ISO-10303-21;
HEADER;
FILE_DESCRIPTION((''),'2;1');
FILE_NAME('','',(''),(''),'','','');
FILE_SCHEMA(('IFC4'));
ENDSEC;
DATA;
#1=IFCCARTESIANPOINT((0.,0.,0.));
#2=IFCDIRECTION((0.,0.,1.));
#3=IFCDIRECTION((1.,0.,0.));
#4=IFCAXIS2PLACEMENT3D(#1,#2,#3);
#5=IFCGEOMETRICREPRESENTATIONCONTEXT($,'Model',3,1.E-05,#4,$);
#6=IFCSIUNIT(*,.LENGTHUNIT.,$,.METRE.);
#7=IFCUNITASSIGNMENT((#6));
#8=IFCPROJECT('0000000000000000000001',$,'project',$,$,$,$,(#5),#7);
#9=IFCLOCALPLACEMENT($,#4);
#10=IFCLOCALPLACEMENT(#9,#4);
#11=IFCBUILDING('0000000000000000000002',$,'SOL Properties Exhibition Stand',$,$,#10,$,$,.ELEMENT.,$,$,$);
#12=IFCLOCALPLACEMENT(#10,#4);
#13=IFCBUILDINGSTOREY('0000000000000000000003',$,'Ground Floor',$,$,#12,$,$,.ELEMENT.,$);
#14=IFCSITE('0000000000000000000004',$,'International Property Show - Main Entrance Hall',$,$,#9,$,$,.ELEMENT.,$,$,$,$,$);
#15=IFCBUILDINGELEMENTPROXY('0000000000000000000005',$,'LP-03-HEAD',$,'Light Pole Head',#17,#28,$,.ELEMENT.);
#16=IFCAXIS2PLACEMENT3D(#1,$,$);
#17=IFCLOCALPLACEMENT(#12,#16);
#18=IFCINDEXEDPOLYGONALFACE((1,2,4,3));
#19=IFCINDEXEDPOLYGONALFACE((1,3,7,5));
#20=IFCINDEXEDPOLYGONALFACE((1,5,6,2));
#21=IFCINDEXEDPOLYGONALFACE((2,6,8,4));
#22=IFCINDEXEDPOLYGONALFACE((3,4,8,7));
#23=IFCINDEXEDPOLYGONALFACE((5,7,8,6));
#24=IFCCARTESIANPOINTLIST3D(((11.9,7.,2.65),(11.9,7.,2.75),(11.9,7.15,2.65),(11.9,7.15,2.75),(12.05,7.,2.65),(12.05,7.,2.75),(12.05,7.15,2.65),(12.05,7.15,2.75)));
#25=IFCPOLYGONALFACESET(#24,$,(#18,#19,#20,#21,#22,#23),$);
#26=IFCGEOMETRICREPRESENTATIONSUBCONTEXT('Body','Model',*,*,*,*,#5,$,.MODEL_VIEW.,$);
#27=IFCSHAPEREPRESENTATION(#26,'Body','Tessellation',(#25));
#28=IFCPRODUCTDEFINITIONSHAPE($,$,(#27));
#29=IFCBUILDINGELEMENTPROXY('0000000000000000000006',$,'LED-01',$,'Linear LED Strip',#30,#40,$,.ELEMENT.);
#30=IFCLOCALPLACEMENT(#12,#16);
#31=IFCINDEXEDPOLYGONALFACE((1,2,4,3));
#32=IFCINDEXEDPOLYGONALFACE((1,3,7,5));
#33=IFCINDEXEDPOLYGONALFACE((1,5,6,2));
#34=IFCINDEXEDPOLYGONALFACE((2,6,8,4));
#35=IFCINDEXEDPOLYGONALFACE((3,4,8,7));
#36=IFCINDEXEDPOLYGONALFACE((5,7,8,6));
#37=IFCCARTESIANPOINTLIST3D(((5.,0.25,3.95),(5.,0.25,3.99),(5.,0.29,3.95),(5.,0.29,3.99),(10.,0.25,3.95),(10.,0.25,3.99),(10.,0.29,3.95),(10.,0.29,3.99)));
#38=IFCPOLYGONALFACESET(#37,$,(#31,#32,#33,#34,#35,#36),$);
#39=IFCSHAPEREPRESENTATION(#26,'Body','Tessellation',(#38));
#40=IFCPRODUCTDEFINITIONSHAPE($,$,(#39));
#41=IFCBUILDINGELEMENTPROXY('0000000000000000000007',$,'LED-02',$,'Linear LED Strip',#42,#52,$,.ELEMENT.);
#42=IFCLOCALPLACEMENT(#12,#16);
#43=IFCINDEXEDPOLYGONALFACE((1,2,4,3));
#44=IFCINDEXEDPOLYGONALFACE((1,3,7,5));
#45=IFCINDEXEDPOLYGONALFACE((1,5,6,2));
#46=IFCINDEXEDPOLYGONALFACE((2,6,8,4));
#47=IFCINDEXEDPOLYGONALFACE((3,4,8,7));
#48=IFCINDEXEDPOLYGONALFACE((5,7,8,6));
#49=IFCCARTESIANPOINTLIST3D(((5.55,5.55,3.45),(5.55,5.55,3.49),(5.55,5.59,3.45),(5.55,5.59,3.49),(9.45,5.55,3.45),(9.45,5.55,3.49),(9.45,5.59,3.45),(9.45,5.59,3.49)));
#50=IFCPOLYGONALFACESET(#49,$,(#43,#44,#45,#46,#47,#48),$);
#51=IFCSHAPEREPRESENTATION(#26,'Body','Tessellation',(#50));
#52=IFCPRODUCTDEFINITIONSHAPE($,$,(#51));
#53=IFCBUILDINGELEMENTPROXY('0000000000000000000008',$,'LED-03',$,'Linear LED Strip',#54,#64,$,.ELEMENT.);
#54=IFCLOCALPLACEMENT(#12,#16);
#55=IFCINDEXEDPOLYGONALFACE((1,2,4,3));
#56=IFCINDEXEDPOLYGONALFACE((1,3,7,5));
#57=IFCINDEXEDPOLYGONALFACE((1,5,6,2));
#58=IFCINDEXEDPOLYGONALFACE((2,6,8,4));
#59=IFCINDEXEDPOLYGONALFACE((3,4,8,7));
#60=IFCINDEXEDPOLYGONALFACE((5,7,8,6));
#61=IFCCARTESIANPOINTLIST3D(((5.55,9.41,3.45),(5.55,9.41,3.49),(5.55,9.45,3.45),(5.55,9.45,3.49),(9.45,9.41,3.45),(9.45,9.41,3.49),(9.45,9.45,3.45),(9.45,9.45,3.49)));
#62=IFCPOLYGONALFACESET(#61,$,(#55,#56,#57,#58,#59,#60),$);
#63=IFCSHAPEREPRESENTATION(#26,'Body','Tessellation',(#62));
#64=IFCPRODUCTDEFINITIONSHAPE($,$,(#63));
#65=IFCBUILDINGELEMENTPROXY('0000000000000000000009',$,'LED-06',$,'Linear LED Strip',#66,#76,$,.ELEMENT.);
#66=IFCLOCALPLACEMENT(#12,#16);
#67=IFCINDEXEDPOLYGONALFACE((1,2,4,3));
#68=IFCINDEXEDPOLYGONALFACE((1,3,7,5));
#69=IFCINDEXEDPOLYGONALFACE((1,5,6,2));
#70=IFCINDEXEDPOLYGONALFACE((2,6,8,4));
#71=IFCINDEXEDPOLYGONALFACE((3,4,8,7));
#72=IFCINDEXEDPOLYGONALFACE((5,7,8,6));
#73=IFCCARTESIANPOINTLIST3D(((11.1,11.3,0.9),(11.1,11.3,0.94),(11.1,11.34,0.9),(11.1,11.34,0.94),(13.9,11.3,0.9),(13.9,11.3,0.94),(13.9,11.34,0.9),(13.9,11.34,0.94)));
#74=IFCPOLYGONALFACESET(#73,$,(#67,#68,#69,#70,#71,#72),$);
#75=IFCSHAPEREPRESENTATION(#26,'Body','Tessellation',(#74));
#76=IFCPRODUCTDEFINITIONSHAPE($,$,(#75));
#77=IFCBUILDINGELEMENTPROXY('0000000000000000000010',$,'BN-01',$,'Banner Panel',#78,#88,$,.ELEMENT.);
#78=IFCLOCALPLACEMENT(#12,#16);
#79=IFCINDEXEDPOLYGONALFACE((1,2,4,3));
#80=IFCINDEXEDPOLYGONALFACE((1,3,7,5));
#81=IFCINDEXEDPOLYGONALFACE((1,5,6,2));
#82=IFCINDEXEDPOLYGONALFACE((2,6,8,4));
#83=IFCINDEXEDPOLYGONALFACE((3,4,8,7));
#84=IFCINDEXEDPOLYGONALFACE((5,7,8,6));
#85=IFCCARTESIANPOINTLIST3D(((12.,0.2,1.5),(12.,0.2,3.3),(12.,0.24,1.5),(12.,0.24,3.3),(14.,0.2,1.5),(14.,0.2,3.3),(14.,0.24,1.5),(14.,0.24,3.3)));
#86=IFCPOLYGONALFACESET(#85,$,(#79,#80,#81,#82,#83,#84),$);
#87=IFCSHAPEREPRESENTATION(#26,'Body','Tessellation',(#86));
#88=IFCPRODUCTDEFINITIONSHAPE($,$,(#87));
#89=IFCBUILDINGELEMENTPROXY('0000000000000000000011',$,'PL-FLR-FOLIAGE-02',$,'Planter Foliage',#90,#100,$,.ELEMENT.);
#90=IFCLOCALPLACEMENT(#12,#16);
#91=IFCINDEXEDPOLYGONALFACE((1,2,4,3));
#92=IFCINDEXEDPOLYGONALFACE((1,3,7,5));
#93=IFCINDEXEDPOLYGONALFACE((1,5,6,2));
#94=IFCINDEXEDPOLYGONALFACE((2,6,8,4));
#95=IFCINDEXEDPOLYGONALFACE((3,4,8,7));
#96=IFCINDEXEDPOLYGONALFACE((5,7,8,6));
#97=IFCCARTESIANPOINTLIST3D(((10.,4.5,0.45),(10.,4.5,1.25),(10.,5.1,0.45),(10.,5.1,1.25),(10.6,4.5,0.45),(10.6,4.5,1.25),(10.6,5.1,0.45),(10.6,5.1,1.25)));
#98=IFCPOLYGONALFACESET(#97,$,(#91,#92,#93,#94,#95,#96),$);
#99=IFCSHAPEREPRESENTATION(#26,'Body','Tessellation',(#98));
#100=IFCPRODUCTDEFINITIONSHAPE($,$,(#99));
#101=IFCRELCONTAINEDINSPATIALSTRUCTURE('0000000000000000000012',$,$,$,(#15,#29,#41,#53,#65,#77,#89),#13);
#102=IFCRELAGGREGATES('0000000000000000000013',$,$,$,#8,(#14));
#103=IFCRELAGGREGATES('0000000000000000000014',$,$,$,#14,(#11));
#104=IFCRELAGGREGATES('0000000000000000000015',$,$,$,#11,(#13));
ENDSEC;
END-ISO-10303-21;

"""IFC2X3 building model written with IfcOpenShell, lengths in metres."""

from ifc_helpers import new_model, si_unit, frame, frame_2d, origin, origin_with_axes, place, context, subcontext, project, spatial, rectangle, extrude, element, save


model = new_model("IFC2X3")

# Units and contexts
model_context = context("Model", 3, precision=1e-05, world=origin_with_axes())
body_context = subcontext(model_context, "Body", "Model", "MODEL_VIEW")
ifc_project = project(units=[si_unit("LENGTHUNIT", "METRE")], contexts=[model_context])

# Site, building, storey
site_placement = place(None, origin_with_axes())
site = spatial("IfcSite", under=ifc_project, at=site_placement, Name="International Property Show - Main Entrance Hall", CompositionType="ELEMENT")
building_placement = place(site_placement, origin_with_axes())
building = spatial("IfcBuilding", under=site, at=building_placement, Name="SOL Properties Exhibition Stand", CompositionType="ELEMENT")
storey_placement = place(building_placement, origin_with_axes())
storey = spatial("IfcBuildingStorey", under=building, at=storey_placement, Name="Ground Floor", CompositionType="ELEMENT")

# Building element proxies
for number, where, z_axis, x_axis, name in (
    (1, (11.9, 7.0, 2.65), (0.0, 0.0, 1.0), (1.0, 0.0, 0.0), "LP-03-HEAD"),
):
    element("IfcBuildingElementProxy", number, at=place(storey_placement, frame(where, z_axis=z_axis, x_axis=x_axis)), inside=storey, Name=name, ObjectType="Light Pole Head", CompositionType="ELEMENT", context=body_context, shape_type="SweptSolid", body=[
        extrude(rectangle(XDim=0.15, YDim=0.15, at=frame_2d((0.075, 0.075))), origin(), (0.0, 0.0, 1.0), 0.1),
    ])
proxy_1_placement = place(storey_placement, frame((5.0, 0.25, 3.95), z_axis=(0.0, 0.0, 1.0), x_axis=(1.0, 0.0, 0.0)))
element("IfcBuildingElementProxy", 2, at=proxy_1_placement, inside=storey, Name="LED-01", ObjectType="Linear LED Strip", CompositionType="ELEMENT", context=body_context, shape_type="SweptSolid", body=[
    extrude(rectangle(XDim=5.0, YDim=0.04, at=frame_2d((2.5, 0.02))), origin(), (0.0, 0.0, 1.0), 0.04),
])
for number, where, z_axis, x_axis, name in (
    (3, (5.55, 5.55, 3.45), (0.0, 0.0, 1.0), (1.0, 0.0, 0.0), "LED-02"),
    (4, (5.55, 9.41, 3.45), (0.0, 0.0, 1.0), (1.0, 0.0, 0.0), "LED-03"),
):
    element("IfcBuildingElementProxy", number, at=place(storey_placement, frame(where, z_axis=z_axis, x_axis=x_axis)), inside=storey, Name=name, ObjectType="Linear LED Strip", CompositionType="ELEMENT", context=body_context, shape_type="SweptSolid", body=[
        extrude(rectangle(XDim=3.9, YDim=0.04, at=frame_2d((1.95, 0.02))), origin(), (0.0, 0.0, 1.0), 0.04),
    ])
proxy_2_placement = place(storey_placement, frame((11.1, 11.3, 0.9), z_axis=(0.0, 0.0, 1.0), x_axis=(1.0, 0.0, 0.0)))
element("IfcBuildingElementProxy", 5, at=proxy_2_placement, inside=storey, Name="LED-06", ObjectType="Linear LED Strip", CompositionType="ELEMENT", context=body_context, shape_type="SweptSolid", body=[
    extrude(rectangle(XDim=2.8, YDim=0.04, at=frame_2d((1.4, 0.02))), origin(), (0.0, 0.0, 1.0), 0.04),
])
proxy_3_placement = place(storey_placement, frame((12.0, 0.2, 1.5), z_axis=(0.0, 0.0, 1.0), x_axis=(1.0, 0.0, 0.0)))
element("IfcBuildingElementProxy", 6, at=proxy_3_placement, inside=storey, Name="BN-01", ObjectType="Banner Panel", CompositionType="ELEMENT", context=body_context, shape_type="SweptSolid", body=[
    extrude(rectangle(XDim=2.0, YDim=0.04, at=frame_2d((1.0, 0.02))), origin(), (0.0, 0.0, 1.0), 1.8),
])
proxy_4_placement = place(storey_placement, frame((10.0, 4.5, 0.45), z_axis=(0.0, 0.0, 1.0), x_axis=(1.0, 0.0, 0.0)))
element("IfcBuildingElementProxy", 7, at=proxy_4_placement, inside=storey, Name="PL-FLR-FOLIAGE-02", ObjectType="Planter Foliage", CompositionType="ELEMENT", context=body_context, shape_type="SweptSolid", body=[
    extrude(rectangle(XDim=0.6, YDim=0.6, at=frame_2d((0.3, 0.3))), origin(), (0.0, 0.0, 1.0), 0.8),
])

save(model, "model.ifc")
